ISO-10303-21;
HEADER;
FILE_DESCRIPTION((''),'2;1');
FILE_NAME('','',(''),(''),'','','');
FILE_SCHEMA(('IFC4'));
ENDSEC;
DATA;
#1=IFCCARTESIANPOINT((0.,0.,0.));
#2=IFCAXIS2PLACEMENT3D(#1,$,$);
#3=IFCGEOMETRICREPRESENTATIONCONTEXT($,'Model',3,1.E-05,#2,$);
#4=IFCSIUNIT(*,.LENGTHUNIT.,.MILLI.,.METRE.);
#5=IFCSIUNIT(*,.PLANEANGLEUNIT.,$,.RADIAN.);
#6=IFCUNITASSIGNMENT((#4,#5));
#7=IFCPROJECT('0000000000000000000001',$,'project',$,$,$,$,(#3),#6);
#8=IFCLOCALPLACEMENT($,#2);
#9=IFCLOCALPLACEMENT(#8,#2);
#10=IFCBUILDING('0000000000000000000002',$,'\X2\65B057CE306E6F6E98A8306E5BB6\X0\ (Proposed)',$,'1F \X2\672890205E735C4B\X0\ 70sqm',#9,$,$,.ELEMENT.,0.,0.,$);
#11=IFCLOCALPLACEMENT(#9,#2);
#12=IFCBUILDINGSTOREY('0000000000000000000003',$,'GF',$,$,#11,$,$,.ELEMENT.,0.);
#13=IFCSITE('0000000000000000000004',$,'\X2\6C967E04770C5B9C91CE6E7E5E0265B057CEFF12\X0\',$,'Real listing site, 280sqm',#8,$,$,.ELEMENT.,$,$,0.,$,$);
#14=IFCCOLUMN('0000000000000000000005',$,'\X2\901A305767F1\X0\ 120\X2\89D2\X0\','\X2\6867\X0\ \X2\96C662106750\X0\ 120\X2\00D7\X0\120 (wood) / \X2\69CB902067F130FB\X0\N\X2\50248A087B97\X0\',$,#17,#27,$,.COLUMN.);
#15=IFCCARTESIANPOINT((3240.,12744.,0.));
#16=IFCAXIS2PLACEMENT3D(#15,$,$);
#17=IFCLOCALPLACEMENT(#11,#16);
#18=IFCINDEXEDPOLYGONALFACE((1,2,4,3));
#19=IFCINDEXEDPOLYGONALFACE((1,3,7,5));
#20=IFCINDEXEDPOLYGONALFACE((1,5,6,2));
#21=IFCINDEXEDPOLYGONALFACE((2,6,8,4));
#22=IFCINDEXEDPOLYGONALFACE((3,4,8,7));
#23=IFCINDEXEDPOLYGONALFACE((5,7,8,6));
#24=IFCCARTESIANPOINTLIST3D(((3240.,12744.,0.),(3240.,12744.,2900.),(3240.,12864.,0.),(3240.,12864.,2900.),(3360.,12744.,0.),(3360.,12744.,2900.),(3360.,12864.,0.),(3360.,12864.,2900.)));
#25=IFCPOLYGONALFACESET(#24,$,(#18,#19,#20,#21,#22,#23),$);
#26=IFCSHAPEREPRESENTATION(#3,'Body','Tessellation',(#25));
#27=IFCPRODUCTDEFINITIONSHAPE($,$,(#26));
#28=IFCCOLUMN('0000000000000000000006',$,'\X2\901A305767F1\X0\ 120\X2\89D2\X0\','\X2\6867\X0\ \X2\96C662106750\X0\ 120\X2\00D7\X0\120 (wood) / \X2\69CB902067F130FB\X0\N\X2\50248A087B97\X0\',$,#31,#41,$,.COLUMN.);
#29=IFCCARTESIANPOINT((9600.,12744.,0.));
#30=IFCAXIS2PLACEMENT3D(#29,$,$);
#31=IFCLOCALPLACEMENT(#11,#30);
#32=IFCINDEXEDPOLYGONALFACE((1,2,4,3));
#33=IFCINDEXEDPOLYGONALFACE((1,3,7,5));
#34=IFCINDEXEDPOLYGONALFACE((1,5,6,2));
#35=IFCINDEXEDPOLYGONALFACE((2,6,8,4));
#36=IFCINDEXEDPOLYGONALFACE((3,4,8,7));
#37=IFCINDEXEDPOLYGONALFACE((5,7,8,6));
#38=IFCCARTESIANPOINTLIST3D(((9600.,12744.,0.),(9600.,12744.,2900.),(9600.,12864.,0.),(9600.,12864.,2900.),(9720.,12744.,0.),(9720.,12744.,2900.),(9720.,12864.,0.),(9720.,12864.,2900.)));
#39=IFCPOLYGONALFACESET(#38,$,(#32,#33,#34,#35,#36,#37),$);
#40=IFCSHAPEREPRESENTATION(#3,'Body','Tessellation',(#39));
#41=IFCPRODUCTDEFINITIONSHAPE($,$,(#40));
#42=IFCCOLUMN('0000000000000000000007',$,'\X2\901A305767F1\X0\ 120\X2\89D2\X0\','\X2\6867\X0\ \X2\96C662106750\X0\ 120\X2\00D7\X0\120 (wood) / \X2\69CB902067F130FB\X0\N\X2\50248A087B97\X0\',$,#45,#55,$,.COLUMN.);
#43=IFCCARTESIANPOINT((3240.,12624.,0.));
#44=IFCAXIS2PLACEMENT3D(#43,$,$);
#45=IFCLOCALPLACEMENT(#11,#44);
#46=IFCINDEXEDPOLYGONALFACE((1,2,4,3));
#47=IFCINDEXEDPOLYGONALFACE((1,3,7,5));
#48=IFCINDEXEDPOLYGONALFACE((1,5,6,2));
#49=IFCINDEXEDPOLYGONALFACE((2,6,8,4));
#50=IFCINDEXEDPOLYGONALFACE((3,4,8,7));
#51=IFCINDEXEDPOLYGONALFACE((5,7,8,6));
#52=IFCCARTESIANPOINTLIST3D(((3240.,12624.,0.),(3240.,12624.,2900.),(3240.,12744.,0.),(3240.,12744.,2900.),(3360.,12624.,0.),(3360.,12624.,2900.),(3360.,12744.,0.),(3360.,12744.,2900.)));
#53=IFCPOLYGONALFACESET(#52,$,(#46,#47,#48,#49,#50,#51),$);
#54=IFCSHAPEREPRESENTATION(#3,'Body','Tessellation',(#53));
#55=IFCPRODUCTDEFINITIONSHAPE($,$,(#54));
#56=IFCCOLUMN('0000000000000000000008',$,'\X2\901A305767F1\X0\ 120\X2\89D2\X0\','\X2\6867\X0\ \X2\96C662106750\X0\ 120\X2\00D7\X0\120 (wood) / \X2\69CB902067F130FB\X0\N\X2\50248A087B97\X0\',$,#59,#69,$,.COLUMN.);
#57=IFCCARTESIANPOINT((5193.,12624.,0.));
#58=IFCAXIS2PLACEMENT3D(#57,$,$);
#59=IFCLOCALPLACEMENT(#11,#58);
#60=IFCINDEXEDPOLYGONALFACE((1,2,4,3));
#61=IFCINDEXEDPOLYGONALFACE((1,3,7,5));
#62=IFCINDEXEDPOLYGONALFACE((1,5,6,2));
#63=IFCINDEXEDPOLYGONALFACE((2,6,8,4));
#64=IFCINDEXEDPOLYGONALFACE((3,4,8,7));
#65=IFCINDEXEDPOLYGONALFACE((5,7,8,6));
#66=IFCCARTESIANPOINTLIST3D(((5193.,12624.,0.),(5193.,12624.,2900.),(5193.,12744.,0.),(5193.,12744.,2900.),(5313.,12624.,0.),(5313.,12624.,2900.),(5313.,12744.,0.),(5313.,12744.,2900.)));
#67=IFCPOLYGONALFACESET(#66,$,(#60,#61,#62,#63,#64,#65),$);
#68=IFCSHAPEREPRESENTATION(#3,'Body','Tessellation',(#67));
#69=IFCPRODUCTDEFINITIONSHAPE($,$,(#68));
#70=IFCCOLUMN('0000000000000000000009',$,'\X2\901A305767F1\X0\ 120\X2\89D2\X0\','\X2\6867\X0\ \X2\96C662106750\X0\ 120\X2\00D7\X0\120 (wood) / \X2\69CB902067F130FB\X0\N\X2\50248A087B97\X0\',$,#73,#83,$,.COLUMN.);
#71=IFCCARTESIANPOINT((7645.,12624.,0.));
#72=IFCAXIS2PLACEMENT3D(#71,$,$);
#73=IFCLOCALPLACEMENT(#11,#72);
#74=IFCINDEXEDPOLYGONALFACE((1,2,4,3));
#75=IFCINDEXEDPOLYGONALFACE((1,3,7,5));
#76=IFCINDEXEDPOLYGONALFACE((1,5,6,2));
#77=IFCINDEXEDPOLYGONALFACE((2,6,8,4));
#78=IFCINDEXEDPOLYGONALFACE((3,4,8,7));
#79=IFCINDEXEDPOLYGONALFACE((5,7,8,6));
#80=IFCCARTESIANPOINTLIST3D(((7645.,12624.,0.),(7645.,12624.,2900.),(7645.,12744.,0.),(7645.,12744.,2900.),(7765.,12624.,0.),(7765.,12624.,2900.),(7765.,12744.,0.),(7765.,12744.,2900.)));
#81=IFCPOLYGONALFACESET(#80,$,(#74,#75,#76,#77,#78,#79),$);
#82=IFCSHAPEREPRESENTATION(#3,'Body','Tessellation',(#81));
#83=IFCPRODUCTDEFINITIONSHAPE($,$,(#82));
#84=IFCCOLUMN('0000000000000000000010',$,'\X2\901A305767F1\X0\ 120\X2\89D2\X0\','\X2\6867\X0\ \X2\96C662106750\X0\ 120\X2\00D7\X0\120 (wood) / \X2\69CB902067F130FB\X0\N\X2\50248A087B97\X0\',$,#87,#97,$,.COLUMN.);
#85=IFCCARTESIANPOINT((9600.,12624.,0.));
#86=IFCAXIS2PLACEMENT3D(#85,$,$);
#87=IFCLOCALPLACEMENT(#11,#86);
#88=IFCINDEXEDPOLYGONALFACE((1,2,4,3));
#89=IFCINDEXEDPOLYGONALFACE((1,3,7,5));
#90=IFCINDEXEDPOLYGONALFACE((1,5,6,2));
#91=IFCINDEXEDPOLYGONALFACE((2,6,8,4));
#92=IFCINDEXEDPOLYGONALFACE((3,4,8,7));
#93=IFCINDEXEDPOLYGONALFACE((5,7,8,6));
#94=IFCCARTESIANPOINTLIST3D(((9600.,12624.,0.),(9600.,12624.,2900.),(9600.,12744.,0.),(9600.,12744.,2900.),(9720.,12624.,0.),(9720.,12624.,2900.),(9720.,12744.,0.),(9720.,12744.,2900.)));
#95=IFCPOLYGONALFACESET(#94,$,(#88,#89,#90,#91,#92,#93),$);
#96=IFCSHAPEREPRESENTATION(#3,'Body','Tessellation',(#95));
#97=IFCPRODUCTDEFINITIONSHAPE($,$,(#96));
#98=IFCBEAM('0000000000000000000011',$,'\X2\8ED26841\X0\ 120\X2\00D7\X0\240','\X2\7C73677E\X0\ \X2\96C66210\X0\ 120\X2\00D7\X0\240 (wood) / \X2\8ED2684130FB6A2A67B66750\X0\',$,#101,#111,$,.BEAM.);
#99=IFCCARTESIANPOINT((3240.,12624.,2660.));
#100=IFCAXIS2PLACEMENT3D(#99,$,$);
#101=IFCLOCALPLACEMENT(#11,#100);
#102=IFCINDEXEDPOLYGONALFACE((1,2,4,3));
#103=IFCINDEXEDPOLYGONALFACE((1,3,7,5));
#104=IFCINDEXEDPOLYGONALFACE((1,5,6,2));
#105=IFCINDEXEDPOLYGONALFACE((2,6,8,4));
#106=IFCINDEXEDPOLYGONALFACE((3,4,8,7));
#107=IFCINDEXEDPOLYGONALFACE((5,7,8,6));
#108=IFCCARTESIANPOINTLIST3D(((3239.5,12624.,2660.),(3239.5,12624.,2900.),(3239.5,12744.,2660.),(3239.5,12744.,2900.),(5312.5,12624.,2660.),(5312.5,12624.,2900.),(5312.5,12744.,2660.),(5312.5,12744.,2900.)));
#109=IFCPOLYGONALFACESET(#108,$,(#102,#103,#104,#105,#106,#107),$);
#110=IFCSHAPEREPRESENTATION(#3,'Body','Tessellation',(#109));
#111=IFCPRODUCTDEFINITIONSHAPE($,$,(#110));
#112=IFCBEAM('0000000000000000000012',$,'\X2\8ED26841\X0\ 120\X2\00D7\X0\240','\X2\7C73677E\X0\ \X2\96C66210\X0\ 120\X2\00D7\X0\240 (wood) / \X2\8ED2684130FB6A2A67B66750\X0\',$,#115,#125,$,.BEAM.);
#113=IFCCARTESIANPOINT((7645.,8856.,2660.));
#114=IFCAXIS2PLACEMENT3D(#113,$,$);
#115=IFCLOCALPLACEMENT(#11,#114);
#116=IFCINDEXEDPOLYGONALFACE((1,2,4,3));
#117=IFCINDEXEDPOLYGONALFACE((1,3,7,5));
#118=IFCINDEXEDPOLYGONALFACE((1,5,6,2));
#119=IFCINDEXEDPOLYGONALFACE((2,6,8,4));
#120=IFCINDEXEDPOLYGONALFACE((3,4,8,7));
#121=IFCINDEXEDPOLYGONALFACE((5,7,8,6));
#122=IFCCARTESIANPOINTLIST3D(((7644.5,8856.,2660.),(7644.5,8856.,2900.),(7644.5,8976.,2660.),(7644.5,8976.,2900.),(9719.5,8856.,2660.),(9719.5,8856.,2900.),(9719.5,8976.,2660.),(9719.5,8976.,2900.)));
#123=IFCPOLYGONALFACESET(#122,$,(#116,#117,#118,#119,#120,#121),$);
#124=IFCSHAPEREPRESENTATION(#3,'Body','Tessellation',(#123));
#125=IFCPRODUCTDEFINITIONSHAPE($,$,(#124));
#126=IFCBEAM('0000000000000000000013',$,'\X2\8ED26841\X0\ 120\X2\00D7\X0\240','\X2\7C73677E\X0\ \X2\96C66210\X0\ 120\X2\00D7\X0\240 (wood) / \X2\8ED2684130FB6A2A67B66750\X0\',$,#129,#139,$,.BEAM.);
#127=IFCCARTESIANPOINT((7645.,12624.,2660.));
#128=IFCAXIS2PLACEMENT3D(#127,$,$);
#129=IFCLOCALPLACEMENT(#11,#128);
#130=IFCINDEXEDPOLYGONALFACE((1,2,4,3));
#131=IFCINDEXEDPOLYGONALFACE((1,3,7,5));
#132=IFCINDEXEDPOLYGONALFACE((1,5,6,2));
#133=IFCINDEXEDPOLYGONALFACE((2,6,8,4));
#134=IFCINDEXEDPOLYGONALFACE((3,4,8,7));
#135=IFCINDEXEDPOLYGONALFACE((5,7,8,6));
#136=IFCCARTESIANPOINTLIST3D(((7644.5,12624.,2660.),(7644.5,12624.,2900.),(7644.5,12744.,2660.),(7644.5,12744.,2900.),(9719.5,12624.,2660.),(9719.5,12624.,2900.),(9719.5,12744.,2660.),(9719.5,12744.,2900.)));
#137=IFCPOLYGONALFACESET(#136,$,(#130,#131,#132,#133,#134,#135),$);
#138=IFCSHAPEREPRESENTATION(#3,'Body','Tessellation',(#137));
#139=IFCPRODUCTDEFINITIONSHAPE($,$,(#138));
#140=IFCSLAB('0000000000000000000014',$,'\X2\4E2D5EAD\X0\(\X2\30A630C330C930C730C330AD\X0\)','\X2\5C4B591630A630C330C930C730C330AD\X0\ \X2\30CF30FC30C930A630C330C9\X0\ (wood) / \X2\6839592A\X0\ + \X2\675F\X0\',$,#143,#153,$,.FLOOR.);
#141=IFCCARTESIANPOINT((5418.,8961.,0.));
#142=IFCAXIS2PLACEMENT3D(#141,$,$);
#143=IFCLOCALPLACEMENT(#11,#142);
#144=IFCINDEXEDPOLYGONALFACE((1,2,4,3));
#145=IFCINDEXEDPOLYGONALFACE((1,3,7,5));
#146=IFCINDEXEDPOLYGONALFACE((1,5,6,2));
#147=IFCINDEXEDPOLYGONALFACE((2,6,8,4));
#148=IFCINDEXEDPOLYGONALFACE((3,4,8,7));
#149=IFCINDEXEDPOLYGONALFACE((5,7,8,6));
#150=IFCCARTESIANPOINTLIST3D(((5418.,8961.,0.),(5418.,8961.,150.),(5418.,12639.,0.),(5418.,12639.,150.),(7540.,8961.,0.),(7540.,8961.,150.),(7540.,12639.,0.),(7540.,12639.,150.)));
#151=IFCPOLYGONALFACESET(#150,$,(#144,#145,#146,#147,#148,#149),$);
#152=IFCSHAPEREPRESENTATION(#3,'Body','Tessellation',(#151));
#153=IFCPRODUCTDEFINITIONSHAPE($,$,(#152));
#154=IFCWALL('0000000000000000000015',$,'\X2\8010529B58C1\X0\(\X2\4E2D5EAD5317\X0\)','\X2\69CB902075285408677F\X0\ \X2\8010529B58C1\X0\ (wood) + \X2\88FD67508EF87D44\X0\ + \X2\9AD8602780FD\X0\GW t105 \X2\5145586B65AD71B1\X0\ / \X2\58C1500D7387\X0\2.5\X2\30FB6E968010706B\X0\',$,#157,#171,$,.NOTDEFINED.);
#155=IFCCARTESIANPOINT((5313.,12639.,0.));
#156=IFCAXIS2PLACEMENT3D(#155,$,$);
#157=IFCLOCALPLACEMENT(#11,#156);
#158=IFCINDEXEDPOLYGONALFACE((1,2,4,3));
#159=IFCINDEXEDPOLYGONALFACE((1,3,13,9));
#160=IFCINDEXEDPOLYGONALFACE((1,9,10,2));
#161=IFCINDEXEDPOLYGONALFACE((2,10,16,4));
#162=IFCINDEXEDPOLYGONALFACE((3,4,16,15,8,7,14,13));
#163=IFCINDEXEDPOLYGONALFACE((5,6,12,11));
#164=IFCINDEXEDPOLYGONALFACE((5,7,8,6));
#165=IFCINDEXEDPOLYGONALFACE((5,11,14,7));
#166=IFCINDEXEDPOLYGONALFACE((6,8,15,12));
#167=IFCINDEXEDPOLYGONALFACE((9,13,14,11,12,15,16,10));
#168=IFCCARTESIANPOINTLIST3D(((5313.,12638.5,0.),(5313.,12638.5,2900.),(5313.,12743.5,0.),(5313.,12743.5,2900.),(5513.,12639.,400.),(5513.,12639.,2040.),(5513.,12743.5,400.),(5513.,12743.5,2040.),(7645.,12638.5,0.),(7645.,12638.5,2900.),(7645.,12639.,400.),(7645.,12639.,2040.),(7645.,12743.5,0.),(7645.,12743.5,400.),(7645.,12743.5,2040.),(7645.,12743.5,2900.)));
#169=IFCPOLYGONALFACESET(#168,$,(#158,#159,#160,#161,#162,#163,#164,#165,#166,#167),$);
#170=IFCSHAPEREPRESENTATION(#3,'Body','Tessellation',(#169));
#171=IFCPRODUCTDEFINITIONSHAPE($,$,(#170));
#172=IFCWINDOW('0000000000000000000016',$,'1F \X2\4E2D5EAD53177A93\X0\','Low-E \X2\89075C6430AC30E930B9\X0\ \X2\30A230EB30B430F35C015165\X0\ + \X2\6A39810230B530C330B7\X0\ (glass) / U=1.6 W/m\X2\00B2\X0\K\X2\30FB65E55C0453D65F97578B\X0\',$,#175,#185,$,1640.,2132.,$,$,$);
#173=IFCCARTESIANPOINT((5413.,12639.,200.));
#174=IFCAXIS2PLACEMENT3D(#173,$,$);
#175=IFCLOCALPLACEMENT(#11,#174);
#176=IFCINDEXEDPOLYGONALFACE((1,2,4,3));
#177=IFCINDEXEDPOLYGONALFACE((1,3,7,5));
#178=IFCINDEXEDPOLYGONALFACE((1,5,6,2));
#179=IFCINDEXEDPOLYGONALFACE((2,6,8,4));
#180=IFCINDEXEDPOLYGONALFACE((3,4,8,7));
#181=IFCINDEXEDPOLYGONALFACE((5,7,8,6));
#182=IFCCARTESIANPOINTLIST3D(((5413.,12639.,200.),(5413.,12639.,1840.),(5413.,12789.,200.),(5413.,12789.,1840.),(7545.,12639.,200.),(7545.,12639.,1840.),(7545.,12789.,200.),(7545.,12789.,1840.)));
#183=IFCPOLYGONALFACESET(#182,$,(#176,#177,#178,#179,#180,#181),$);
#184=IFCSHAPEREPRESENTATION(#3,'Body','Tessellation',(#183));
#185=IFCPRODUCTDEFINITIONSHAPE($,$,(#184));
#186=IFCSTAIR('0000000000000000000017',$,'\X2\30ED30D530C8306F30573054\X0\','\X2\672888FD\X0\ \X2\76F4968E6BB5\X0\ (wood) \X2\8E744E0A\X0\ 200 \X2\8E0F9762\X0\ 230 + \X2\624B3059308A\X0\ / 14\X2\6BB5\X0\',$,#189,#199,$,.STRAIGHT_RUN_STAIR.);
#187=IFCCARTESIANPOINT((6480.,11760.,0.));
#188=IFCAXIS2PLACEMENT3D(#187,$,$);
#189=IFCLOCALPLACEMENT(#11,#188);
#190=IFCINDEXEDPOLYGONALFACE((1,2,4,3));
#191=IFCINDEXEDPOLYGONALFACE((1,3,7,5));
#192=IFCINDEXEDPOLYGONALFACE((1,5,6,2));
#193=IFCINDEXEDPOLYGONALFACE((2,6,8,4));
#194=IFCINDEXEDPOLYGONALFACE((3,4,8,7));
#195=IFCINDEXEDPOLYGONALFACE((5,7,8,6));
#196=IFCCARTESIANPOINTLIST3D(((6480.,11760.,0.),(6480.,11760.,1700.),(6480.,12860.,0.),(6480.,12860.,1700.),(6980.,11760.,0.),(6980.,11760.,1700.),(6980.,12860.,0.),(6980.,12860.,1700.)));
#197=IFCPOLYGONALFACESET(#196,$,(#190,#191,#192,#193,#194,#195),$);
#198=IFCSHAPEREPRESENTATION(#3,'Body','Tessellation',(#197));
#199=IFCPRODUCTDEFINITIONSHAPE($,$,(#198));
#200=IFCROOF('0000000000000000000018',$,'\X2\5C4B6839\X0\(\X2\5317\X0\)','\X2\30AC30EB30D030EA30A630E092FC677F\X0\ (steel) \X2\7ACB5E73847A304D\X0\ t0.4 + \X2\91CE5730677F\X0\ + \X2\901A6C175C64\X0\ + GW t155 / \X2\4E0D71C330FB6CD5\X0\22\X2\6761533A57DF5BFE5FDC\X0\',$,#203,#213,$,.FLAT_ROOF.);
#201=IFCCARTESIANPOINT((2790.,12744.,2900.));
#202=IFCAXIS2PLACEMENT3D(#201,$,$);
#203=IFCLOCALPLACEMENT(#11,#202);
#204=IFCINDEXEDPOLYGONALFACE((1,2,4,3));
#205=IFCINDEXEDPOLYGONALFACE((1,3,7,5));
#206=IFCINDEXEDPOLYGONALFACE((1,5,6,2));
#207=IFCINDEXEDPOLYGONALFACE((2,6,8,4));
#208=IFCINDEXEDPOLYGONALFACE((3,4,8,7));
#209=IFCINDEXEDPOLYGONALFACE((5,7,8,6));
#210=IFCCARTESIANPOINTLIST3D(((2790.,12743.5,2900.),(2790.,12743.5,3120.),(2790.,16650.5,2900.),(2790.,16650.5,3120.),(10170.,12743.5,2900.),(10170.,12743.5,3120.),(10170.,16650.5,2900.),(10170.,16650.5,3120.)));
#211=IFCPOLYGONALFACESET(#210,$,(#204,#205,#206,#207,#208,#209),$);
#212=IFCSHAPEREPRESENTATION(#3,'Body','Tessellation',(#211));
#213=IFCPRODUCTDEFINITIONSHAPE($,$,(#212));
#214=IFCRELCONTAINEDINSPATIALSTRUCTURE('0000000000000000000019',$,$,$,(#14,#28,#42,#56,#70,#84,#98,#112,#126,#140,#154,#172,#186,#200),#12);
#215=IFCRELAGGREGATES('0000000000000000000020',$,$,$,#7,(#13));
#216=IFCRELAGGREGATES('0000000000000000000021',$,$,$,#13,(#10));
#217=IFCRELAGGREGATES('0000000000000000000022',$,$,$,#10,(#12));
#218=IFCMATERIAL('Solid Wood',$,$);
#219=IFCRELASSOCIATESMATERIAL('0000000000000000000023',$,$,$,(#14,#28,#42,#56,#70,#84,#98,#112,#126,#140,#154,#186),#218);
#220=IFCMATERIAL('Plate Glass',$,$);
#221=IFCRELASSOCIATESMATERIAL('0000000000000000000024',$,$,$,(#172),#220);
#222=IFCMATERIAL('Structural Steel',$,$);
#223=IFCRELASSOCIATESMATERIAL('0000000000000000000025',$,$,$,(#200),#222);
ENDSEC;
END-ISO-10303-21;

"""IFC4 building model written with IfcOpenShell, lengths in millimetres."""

from ifc_helpers import new_model, si_unit, frame, frame_2d, origin, place, context, project, spatial, rectangle, extrude, material, element, fill, save


model = new_model("IFC4")

# Units and contexts
model_context = context("Model", 3, precision=1e-05, world=origin())
ifc_project = project(units=[si_unit("LENGTHUNIT", "METRE", prefix="MILLI"), si_unit("PLANEANGLEUNIT", "RADIAN")], contexts=[model_context])

# Site, building, storey
site_placement = place(None, origin())
site = spatial("IfcSite", under=ifc_project, at=site_placement, Name="沖縄県宜野湾市新城２", ObjectType="Real listing site, 280sqm", CompositionType="ELEMENT", RefElevation=0.0)
building_placement = place(site_placement, origin())
building = spatial("IfcBuilding", under=site, at=building_placement, Name="新城の潮風の家 (Proposed)", ObjectType="1F 木造平屋 70sqm", CompositionType="ELEMENT", ElevationOfRefHeight=0.0, ElevationOfTerrain=0.0)
storey_placement = place(building_placement, origin())
storey = spatial("IfcBuildingStorey", under=building, at=storey_placement, Name="GF", CompositionType="ELEMENT", Elevation=0.0)

# Columns
ifc_material_1 = material(Name="Solid Wood")
column_1_placement = place(storey_placement, frame((3240.0, 12744.0, 0.0)))
element("IfcColumn", 1, at=column_1_placement, inside=storey, material=ifc_material_1, Name="通し柱 120角", Description="桧 集成材 120×120 (wood) / 構造柱・N値計算", PredefinedType="COLUMN", context=model_context, shape_type="SweptSolid", body=[
    extrude(rectangle(XDim=120.0, YDim=120.0, at=frame_2d((60.0, 60.0))), frame((3240.0, 12744.0, 0.0)), (0.0, 0.0, 1.0), 2900.0),
])
column_2_placement = place(storey_placement, frame((9600.0, 12744.0, 0.0)))
element("IfcColumn", 2, at=column_2_placement, inside=storey, material=ifc_material_1, Name="通し柱 120角", Description="桧 集成材 120×120 (wood) / 構造柱・N値計算", PredefinedType="COLUMN", context=model_context, shape_type="SweptSolid", body=[
    extrude(rectangle(XDim=120.0, YDim=120.0, at=frame_2d((60.0, 60.0))), frame((9600.0, 12744.0, 0.0)), (0.0, 0.0, 1.0), 2900.0),
])
column_3_placement = place(storey_placement, frame((3240.0, 12624.0, 0.0)))
element("IfcColumn", 3, at=column_3_placement, inside=storey, material=ifc_material_1, Name="通し柱 120角", Description="桧 集成材 120×120 (wood) / 構造柱・N値計算", PredefinedType="COLUMN", context=model_context, shape_type="SweptSolid", body=[
    extrude(rectangle(XDim=120.0, YDim=120.0, at=frame_2d((60.0, 60.0))), frame((3240.0, 12624.0, 0.0)), (0.0, 0.0, 1.0), 2900.0),
])
column_4_placement = place(storey_placement, frame((5193.0, 12624.0, 0.0)))
element("IfcColumn", 4, at=column_4_placement, inside=storey, material=ifc_material_1, Name="通し柱 120角", Description="桧 集成材 120×120 (wood) / 構造柱・N値計算", PredefinedType="COLUMN", context=model_context, shape_type="SweptSolid", body=[
    extrude(rectangle(XDim=120.0, YDim=120.0, at=frame_2d((60.0, 60.0))), frame((5193.0, 12624.0, 0.0)), (0.0, 0.0, 1.0), 2900.0),
])
column_5_placement = place(storey_placement, frame((7645.0, 12624.0, 0.0)))
element("IfcColumn", 5, at=column_5_placement, inside=storey, material=ifc_material_1, Name="通し柱 120角", Description="桧 集成材 120×120 (wood) / 構造柱・N値計算", PredefinedType="COLUMN", context=model_context, shape_type="SweptSolid", body=[
    extrude(rectangle(XDim=120.0, YDim=120.0, at=frame_2d((60.0, 60.0))), frame((7645.0, 12624.0, 0.0)), (0.0, 0.0, 1.0), 2900.0),
])
column_6_placement = place(storey_placement, frame((9600.0, 12624.0, 0.0)))
element("IfcColumn", 6, at=column_6_placement, inside=storey, material=ifc_material_1, Name="通し柱 120角", Description="桧 集成材 120×120 (wood) / 構造柱・N値計算", PredefinedType="COLUMN", context=model_context, shape_type="SweptSolid", body=[
    extrude(rectangle(XDim=120.0, YDim=120.0, at=frame_2d((60.0, 60.0))), frame((9600.0, 12624.0, 0.0)), (0.0, 0.0, 1.0), 2900.0),
])

# Beams
beam_1_placement = place(storey_placement, frame((3240.0, 12624.0, 2660.0)))
element("IfcBeam", 7, at=beam_1_placement, inside=storey, material=ifc_material_1, Name="軒桁 120×240", Description="米松 集成 120×240 (wood) / 軒桁・横架材", PredefinedType="BEAM", context=model_context, shape_type="SweptSolid", body=[
    extrude(rectangle(XDim=2073.0, YDim=120.0, at=frame_2d((1036.0, 60.0))), frame((3240.0, 12624.0, 2660.0)), (0.0, 0.0, 1.0), 240.0),
])
beam_2_placement = place(storey_placement, frame((7645.0, 8856.0, 2660.0)))
element("IfcBeam", 8, at=beam_2_placement, inside=storey, material=ifc_material_1, Name="軒桁 120×240", Description="米松 集成 120×240 (wood) / 軒桁・横架材", PredefinedType="BEAM", context=model_context, shape_type="SweptSolid", body=[
    extrude(rectangle(XDim=2075.0, YDim=120.0, at=frame_2d((1037.0, 60.0))), frame((7645.0, 8856.0, 2660.0)), (0.0, 0.0, 1.0), 240.0),
])
beam_3_placement = place(storey_placement, frame((7645.0, 12624.0, 2660.0)))
element("IfcBeam", 9, at=beam_3_placement, inside=storey, material=ifc_material_1, Name="軒桁 120×240", Description="米松 集成 120×240 (wood) / 軒桁・横架材", PredefinedType="BEAM", context=model_context, shape_type="SweptSolid", body=[
    extrude(rectangle(XDim=2075.0, YDim=120.0, at=frame_2d((1037.0, 60.0))), frame((7645.0, 12624.0, 2660.0)), (0.0, 0.0, 1.0), 240.0),
])

# Slab
slab_1_placement = place(storey_placement, frame((5418.0, 8961.0, 0.0)))
element("IfcSlab", 10, at=slab_1_placement, inside=storey, material=ifc_material_1, Name="中庭(ウッドデッキ)", Description="屋外ウッドデッキ ハードウッド (wood) / 根太 + 束", PredefinedType="FLOOR", context=model_context, shape_type="SweptSolid", body=[
    extrude(rectangle(XDim=2122.0, YDim=3678.0, at=frame_2d((1061.0, 1839.0))), frame((5418.0, 8961.0, 0.0)), (0.0, 0.0, 1.0), 150.0),
])

# Wall, opening, window
wall_placement = place(storey_placement, frame((5313.0, 12639.0, 0.0)))
wall = element("IfcWall", 11, at=wall_placement, inside=storey, material=ifc_material_1, Name="耐力壁(中庭北)", Description="構造用合板 耐力壁 (wood) + 製材軸組 + 高性能GW t105 充填断熱 / 壁倍率2.5・準耐火", PredefinedType="NOTDEFINED", context=model_context, shape_type="SweptSolid", body=[
    extrude(rectangle(XDim=2332.0, YDim=105.0, at=frame_2d((1166.0, 52.0))), frame((5313.0, 12639.0, 0.0)), (0.0, 0.0, 1.0), 2900.0),
])
opening_placement = place(storey_placement, frame((5413.0, 12639.0, 200.0)))
opening = element("IfcOpeningElement", 12, at=opening_placement, cuts=wall, PredefinedType="NOTDEFINED", context=model_context, shape_type="SweptSolid", body=[
    extrude(rectangle(XDim=2132.0, YDim=150.0, at=frame_2d((1066.0, 75.0))), frame((5413.0, 12639.0, 200.0)), (0.0, 0.0, 1.0), 1640.0),
])
ifc_material_2 = material(Name="Plate Glass")
window_placement = place(storey_placement, frame((5413.0, 12639.0, 200.0)))
window = element("IfcWindow", 13, at=window_placement, inside=storey, material=ifc_material_2, Name="1F 中庭北窓", Description="Low-E 複層ガラス アルゴン封入 + 樹脂サッシ (glass) / U=1.6 W/m²K・日射取得型", OverallHeight=1640.0, OverallWidth=2132.0, context=model_context, shape_type="SweptSolid", body=[
    extrude(rectangle(XDim=2132.0, YDim=150.0, at=frame_2d((1066.0, 75.0))), frame((5413.0, 12639.0, 200.0)), (0.0, 0.0, 1.0), 1640.0),
])
fill(opening, window)

# Stair
stair_placement = place(storey_placement, frame((6480.0, 11760.0, 0.0)))
element("IfcStair", 14, at=stair_placement, inside=storey, material=ifc_material_1, Name="ロフトはしご", Description="木製 直階段 (wood) 蹴上 200 踏面 230 + 手すり / 14段", PredefinedType="STRAIGHT_RUN_STAIR", context=model_context, shape_type="SweptSolid", body=[
    extrude(rectangle(XDim=500.0, YDim=1100.0, at=frame_2d((250.0, 550.0))), frame((6480.0, 11760.0, 0.0)), (0.0, 0.0, 1.0), 1700.0),
])

# Roof
ifc_material_3 = material(Name="Structural Steel")
roof_placement = place(storey_placement, frame((2790.0, 12744.0, 2900.0)))
element("IfcRoof", 15, at=roof_placement, inside=storey, material=ifc_material_3, Name="屋根(北)", Description="ガルバリウム鋼板 (steel) 立平葺き t0.4 + 野地板 + 通気層 + GW t155 / 不燃・法22条区域対応", PredefinedType="FLAT_ROOF", context=model_context, shape_type="SweptSolid", body=[
    extrude(rectangle(XDim=7380.0, YDim=3907.0, at=frame_2d((3690.0, 1953.0))), frame((2790.0, 12744.0, 2900.0)), (0.0, 0.0, 1.0), 220.0),
])

save(model, "model.ifc")
